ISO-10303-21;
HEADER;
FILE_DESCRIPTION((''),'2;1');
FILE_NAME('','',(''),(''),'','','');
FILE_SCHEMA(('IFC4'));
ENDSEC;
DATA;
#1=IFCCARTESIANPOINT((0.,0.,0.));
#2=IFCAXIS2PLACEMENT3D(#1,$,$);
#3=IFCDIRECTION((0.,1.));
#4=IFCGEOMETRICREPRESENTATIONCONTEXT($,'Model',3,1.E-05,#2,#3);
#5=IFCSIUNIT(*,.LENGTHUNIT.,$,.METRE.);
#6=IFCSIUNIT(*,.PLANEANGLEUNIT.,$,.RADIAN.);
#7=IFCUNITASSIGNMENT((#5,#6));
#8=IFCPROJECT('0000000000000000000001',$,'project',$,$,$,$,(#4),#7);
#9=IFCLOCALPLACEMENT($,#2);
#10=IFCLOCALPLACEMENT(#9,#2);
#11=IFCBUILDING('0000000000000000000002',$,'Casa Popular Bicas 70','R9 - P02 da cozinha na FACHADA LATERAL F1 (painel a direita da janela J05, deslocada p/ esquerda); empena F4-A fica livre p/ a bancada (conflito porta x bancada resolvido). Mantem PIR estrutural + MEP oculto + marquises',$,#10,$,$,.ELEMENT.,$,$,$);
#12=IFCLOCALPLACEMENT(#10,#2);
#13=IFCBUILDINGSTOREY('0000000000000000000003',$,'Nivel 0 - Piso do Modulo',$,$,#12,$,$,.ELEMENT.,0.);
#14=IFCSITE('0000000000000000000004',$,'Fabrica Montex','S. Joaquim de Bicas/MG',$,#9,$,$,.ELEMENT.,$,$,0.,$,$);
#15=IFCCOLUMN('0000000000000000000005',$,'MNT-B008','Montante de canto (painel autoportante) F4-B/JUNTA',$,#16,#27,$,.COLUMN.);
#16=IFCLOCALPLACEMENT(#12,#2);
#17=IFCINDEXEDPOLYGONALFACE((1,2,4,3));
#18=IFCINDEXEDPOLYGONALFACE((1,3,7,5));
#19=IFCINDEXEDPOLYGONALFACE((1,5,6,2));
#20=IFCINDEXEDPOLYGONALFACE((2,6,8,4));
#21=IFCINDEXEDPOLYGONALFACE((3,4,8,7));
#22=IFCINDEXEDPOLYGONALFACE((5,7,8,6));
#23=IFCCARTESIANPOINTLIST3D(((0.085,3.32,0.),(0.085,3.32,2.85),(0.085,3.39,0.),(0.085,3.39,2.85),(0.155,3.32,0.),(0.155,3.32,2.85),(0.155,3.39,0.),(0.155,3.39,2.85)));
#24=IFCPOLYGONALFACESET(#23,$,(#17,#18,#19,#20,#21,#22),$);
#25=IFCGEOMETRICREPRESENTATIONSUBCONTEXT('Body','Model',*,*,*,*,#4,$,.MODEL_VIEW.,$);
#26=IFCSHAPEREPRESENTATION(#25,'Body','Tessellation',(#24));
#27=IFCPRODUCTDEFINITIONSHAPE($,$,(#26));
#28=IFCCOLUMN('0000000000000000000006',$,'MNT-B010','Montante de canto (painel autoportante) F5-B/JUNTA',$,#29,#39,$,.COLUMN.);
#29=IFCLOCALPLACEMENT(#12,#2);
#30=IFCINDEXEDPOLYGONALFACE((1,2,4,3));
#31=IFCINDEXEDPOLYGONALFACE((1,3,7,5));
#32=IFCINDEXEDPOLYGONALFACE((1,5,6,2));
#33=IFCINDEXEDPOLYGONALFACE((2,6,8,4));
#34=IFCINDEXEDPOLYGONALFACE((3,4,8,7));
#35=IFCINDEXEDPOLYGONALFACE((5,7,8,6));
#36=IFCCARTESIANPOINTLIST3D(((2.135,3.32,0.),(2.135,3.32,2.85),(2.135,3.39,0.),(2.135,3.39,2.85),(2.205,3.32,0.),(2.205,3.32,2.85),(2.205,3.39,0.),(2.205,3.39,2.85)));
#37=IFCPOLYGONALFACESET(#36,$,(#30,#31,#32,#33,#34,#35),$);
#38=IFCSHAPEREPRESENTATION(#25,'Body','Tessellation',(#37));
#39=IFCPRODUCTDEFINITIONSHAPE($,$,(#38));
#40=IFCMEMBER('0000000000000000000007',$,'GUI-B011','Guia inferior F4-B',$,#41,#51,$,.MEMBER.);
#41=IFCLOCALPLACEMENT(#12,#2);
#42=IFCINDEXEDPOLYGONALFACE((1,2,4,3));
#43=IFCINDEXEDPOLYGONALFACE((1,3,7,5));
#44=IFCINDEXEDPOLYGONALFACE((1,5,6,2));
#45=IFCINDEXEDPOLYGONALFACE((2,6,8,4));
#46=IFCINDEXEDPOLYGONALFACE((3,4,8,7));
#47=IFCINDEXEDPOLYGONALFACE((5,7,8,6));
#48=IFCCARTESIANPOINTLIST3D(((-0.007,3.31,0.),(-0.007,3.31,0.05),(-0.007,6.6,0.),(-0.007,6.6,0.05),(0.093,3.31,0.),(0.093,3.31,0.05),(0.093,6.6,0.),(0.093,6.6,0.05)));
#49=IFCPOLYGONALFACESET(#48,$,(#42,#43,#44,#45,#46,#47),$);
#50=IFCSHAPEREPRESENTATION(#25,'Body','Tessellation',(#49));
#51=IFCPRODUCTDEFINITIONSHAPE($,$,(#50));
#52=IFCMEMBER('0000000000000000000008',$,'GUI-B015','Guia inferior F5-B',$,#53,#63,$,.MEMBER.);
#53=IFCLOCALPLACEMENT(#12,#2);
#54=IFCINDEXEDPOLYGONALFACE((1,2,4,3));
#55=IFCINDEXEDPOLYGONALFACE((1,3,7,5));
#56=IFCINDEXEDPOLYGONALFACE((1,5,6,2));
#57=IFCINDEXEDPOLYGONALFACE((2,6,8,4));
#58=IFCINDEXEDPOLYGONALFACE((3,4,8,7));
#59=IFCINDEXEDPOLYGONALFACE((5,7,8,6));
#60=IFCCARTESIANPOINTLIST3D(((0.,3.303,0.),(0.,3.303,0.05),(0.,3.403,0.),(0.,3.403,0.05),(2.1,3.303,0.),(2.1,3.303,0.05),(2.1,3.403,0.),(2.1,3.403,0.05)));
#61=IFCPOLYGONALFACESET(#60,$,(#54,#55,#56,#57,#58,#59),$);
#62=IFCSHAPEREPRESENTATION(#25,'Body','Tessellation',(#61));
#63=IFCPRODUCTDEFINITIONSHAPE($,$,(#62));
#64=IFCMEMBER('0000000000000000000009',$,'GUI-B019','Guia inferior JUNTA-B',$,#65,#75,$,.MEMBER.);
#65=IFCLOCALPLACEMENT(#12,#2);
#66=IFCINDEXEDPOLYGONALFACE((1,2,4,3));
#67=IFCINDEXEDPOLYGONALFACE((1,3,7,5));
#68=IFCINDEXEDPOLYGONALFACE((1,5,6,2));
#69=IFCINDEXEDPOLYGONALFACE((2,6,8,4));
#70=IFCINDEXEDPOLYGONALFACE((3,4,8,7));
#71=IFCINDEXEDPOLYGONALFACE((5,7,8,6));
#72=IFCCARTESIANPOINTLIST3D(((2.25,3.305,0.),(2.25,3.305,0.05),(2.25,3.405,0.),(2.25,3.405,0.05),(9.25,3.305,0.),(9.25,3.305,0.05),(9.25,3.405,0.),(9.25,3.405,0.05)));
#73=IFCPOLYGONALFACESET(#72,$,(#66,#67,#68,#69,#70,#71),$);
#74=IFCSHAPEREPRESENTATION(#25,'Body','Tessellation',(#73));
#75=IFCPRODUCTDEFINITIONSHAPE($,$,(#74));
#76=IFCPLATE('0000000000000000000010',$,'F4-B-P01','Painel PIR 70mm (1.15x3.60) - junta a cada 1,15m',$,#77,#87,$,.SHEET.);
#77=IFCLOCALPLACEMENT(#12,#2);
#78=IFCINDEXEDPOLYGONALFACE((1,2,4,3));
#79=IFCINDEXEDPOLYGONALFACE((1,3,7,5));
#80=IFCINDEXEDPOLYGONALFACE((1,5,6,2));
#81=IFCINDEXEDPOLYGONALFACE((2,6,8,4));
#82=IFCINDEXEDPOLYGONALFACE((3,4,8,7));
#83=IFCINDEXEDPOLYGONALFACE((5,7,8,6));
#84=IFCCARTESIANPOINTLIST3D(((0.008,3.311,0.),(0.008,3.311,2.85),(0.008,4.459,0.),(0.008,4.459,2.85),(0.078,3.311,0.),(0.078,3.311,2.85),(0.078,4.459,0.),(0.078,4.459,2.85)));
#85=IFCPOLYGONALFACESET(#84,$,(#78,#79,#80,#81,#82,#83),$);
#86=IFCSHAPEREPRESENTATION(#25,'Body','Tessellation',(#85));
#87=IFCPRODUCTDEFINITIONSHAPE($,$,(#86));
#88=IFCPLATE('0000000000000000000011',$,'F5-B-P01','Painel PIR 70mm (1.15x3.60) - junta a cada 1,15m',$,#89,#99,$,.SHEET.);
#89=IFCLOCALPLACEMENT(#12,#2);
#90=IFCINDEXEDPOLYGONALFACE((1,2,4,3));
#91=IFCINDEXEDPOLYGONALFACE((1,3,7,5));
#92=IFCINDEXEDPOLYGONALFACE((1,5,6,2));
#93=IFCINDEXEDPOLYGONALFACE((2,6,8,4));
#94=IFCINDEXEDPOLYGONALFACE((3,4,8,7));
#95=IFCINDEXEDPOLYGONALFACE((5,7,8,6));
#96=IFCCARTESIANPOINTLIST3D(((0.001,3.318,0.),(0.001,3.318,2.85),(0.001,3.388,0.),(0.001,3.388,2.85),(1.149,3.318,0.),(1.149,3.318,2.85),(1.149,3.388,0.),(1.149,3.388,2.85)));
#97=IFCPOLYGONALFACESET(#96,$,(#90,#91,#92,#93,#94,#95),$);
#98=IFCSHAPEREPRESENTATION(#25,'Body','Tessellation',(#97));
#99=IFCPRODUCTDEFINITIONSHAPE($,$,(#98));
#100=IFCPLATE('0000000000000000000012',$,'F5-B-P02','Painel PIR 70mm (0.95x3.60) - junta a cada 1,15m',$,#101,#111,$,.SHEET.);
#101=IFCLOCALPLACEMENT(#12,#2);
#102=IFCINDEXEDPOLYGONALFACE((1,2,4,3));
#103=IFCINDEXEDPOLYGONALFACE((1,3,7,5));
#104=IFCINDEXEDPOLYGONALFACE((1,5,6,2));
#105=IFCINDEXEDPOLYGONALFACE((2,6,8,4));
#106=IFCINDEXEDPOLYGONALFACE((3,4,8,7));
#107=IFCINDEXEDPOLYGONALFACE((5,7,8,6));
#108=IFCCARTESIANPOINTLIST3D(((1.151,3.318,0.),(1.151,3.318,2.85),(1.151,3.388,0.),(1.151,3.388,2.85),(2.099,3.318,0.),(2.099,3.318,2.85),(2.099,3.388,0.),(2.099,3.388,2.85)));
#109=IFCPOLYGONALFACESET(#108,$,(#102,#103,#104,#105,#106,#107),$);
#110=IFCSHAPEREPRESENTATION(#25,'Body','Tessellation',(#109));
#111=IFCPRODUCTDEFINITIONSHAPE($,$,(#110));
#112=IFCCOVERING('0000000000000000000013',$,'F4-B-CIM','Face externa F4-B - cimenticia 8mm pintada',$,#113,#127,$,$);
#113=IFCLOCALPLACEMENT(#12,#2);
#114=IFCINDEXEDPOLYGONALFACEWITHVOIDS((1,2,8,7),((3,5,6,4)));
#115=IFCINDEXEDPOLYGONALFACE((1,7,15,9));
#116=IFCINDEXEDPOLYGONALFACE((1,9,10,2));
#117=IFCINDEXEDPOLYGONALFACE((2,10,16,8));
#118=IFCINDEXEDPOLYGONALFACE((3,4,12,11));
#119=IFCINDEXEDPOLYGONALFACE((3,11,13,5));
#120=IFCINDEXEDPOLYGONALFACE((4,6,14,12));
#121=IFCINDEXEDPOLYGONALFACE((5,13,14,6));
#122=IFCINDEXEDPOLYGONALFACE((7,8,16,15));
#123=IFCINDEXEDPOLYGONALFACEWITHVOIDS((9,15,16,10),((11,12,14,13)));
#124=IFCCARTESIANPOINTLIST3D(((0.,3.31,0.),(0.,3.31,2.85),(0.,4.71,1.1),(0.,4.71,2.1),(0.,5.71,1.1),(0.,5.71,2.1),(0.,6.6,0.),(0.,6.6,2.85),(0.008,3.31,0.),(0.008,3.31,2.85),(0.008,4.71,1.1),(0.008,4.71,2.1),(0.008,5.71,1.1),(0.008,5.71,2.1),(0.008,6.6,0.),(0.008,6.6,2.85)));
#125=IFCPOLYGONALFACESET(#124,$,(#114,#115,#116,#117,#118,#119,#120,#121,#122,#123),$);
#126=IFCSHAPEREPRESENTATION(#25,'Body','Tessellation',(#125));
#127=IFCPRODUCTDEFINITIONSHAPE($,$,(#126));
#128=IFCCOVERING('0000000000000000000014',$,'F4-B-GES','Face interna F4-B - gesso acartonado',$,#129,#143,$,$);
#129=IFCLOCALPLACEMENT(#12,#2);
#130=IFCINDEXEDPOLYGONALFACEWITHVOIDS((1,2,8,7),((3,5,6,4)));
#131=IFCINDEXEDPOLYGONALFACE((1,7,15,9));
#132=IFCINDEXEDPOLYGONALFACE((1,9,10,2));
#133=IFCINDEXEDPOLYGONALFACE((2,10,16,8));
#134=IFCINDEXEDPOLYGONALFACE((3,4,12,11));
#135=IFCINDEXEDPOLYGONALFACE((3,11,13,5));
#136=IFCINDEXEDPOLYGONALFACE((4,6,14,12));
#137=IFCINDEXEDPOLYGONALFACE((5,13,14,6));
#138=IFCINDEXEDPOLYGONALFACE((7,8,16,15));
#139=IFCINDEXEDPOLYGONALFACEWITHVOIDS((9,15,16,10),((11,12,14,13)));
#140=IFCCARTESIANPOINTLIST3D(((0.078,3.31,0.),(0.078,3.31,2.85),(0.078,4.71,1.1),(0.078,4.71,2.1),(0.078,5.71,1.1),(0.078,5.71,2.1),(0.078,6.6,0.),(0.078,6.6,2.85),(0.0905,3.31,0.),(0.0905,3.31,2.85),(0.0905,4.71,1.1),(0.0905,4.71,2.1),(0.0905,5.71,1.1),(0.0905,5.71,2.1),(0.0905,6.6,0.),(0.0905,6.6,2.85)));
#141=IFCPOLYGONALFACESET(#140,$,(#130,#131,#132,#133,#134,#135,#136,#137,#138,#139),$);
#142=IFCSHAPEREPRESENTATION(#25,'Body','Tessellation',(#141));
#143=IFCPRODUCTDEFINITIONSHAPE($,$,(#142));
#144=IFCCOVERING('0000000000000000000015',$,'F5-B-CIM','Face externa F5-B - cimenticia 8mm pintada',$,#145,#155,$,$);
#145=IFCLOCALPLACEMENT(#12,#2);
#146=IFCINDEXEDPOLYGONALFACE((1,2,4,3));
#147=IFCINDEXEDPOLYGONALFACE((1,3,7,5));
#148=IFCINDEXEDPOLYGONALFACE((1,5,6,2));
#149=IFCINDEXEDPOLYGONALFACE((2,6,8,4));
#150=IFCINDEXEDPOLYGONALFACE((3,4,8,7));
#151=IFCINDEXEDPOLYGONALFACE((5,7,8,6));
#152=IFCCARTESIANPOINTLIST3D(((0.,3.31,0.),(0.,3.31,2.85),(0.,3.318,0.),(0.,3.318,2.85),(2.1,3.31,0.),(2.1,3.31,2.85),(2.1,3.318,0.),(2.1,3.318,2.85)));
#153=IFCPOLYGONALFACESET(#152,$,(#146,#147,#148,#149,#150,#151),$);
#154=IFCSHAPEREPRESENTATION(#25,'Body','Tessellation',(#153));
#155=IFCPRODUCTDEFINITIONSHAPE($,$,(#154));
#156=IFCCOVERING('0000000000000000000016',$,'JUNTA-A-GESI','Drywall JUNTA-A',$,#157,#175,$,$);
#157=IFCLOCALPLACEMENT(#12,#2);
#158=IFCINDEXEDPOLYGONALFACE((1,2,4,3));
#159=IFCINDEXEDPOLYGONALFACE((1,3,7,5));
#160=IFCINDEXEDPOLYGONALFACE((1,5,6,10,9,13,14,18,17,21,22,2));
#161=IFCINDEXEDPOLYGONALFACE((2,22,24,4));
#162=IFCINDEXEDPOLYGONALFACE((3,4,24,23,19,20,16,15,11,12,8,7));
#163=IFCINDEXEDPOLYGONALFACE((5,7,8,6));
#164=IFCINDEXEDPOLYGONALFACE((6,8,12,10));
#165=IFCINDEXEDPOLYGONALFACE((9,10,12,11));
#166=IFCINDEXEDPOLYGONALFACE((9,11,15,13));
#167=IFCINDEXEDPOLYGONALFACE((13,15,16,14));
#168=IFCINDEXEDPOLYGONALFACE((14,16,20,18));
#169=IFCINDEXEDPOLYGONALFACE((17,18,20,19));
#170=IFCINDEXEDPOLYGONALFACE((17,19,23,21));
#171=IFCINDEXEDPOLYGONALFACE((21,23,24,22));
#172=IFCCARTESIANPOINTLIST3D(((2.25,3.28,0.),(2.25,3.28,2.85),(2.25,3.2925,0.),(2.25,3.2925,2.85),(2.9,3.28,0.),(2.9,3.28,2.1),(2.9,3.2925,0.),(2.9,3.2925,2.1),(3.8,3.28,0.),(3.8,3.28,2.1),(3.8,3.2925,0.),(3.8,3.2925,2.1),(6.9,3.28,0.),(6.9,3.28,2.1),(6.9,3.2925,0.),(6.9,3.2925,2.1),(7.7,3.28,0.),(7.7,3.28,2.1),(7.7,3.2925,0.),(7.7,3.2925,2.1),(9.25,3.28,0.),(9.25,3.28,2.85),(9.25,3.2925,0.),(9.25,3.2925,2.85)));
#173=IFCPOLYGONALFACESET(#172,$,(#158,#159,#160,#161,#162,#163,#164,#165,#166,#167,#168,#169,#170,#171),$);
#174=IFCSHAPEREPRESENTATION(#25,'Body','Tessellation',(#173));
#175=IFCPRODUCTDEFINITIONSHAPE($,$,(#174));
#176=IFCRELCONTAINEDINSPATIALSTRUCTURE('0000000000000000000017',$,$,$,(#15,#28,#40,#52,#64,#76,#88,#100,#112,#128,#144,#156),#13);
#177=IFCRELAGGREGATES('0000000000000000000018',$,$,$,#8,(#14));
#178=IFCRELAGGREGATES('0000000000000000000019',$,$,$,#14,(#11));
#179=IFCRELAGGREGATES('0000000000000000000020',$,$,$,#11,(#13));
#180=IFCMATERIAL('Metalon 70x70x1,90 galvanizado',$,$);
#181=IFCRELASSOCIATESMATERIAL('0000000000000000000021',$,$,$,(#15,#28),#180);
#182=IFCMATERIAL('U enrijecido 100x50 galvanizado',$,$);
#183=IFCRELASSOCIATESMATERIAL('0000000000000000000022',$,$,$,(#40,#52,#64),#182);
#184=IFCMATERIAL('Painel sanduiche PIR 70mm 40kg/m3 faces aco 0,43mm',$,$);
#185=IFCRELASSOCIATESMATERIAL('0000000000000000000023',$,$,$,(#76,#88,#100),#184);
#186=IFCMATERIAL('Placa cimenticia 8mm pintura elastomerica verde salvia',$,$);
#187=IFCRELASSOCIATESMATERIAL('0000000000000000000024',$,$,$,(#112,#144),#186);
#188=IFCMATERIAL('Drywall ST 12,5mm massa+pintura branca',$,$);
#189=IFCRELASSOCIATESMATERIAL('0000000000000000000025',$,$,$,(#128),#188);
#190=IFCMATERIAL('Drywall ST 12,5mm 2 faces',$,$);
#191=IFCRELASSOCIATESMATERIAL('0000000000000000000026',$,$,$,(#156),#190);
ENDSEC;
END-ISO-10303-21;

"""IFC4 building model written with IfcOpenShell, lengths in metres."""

from ifc_helpers import new_model, si_unit, direction, frame, frame_2d, origin, origin_2d, place, context, subcontext, project, spatial, rectangle, extrude, material, element, save


model = new_model("IFC4")

# Units and contexts
model_context = context("Model", 3, precision=1e-05, world=origin(), true_north=direction((0.0, 1.0)))
body_context = subcontext(model_context, "Body", "Model", "MODEL_VIEW")
ifc_project = project(units=[si_unit("LENGTHUNIT", "METRE"), si_unit("PLANEANGLEUNIT", "RADIAN")], contexts=[model_context])

# Site, building, storey
site_placement = place(None, origin())
site = spatial("IfcSite", under=ifc_project, at=site_placement, Name="Fabrica Montex", Description="S. Joaquim de Bicas/MG", CompositionType="ELEMENT", RefElevation=0.0)
building_placement = place(site_placement, origin())
building = spatial("IfcBuilding", under=site, at=building_placement, Name="Casa Popular Bicas 70", Description="R9 - P02 da cozinha na FACHADA LATERAL F1 (painel a direita da janela J05, deslocada p/ esquerda); empena F4-A fica livre p/ a bancada (conflito porta x bancada resolvido). Mantem PIR estrutural + MEP oculto + marquises", CompositionType="ELEMENT")
storey_placement = place(building_placement, origin())
storey = spatial("IfcBuildingStorey", under=building, at=storey_placement, Name="Nivel 0 - Piso do Modulo", CompositionType="ELEMENT", Elevation=0.0)

# Columns
ifc_material_1 = material(Name="Metalon 70x70x1,90 galvanizado")
for number, where, name, description in (
    (1, (0.12, 3.355, 0.0), "MNT-B008", "Montante de canto (painel autoportante) F4-B/JUNTA"),
    (2, (2.17, 3.355, 0.0), "MNT-B010", "Montante de canto (painel autoportante) F5-B/JUNTA"),
):
    element("IfcColumn", number, at=place(storey_placement, frame(where)), inside=storey, material=ifc_material_1, Name=name, Description=description, PredefinedType="COLUMN", context=body_context, shape_type="SweptSolid", body=[
        extrude(rectangle(XDim=0.07, YDim=0.07, at=origin_2d()), origin(), (0.0, 0.0, 1.0), 2.85),
    ])

# Members
ifc_material_2 = material(Name="U enrijecido 100x50 galvanizado")
member_1_placement = place(storey_placement, frame((0.043, 3.31, 0.025), z_axis=(0.0, 1.0, 0.0), x_axis=(0.0, 0.0, 1.0)))
element("IfcMember", 3, at=member_1_placement, inside=storey, material=ifc_material_2, Name="GUI-B011", Description="Guia inferior F4-B", PredefinedType="MEMBER", context=body_context, shape_type="SweptSolid", body=[
    extrude(rectangle(XDim=0.05, YDim=0.1, at=origin_2d()), origin(), (0.0, 0.0, 1.0), 3.29),
])
member_2_placement = place(storey_placement, frame((0.0, 3.353, 0.025), z_axis=(1.0, 0.0, 0.0), x_axis=(0.0, 0.0, 1.0)))
element("IfcMember", 4, at=member_2_placement, inside=storey, material=ifc_material_2, Name="GUI-B015", Description="Guia inferior F5-B", PredefinedType="MEMBER", context=body_context, shape_type="SweptSolid", body=[
    extrude(rectangle(XDim=0.05, YDim=0.1, at=origin_2d()), origin(), (0.0, 0.0, 1.0), 2.1),
])
member_3_placement = place(storey_placement, frame((2.25, 3.355, 0.025), z_axis=(1.0, 0.0, 0.0), x_axis=(0.0, 0.0, 1.0)))
element("IfcMember", 5, at=member_3_placement, inside=storey, material=ifc_material_2, Name="GUI-B019", Description="Guia inferior JUNTA-B", PredefinedType="MEMBER", context=body_context, shape_type="SweptSolid", body=[
    extrude(rectangle(XDim=0.05, YDim=0.1, at=origin_2d()), origin(), (0.0, 0.0, 1.0), 7.0),
])

# Plates
ifc_material_3 = material(Name="Painel sanduiche PIR 70mm 40kg/m3 faces aco 0,43mm")
for number, where, x_axis, name in (
    (6, (0.043, 3.311, 0.0), (0.0, 1.0, 0.0), "F4-B-P01"),
    (7, (0.001, 3.353, 0.0), (1.0, 0.0, 0.0), "F5-B-P01"),
):
    element("IfcPlate", number, at=place(storey_placement, frame(where, x_axis=x_axis)), inside=storey, material=ifc_material_3, Name=name, Description="Painel PIR 70mm (1.15x3.60) - junta a cada 1,15m", PredefinedType="SHEET", context=body_context, shape_type="SweptSolid", body=[
        extrude(rectangle(XDim=1.148, YDim=0.07, at=frame_2d((0.574, 0.0))), origin(), (0.0, 0.0, 1.0), 2.85),
    ])
plate_1_placement = place(storey_placement, frame((1.151, 3.353, 0.0), x_axis=(1.0, 0.0, 0.0)))
element("IfcPlate", 8, at=plate_1_placement, inside=storey, material=ifc_material_3, Name="F5-B-P02", Description="Painel PIR 70mm (0.95x3.60) - junta a cada 1,15m", PredefinedType="SHEET", context=body_context, shape_type="SweptSolid", body=[
    extrude(rectangle(XDim=0.948, YDim=0.07, at=frame_2d((0.474, 0.0))), origin(), (0.0, 0.0, 1.0), 2.85),
])

# Coverings, openings
ifc_material_4 = material(Name="Placa cimenticia 8mm pintura elastomerica verde salvia")
covering_1_placement = place(storey_placement, frame((0.004, 3.31, 0.0), x_axis=(0.0, 1.0, 0.0)))
covering_1 = element("IfcCovering", 9, at=covering_1_placement, inside=storey, material=ifc_material_4, Name="F4-B-CIM", Description="Face externa F4-B - cimenticia 8mm pintada", context=body_context, shape_type="SweptSolid", body=[
    extrude(rectangle(XDim=3.29, YDim=0.008, at=frame_2d((1.645, 0.0))), origin(), (0.0, 0.0, 1.0), 2.85),
])
opening_1_placement = place(storey_placement, frame((0.004, 5.21, 1.1)))
element("IfcOpeningElement", 10, at=opening_1_placement, cuts=covering_1, PredefinedType="OPENING", context=body_context, shape_type="SweptSolid", body=[
    extrude(rectangle(XDim=0.038, YDim=1.0, at=origin_2d()), origin(), (0.0, 0.0, 1.0), 1.0),
])
ifc_material_5 = material(Name="Drywall ST 12,5mm massa+pintura branca")
covering_2_placement = place(storey_placement, frame((0.0843, 3.31, 0.0), x_axis=(0.0, 1.0, 0.0)))
covering_2 = element("IfcCovering", 11, at=covering_2_placement, inside=storey, material=ifc_material_5, Name="F4-B-GES", Description="Face interna F4-B - gesso acartonado", context=body_context, shape_type="SweptSolid", body=[
    extrude(rectangle(XDim=3.29, YDim=0.0125, at=frame_2d((1.645, 0.0))), origin(), (0.0, 0.0, 1.0), 2.85),
])
opening_2_placement = place(storey_placement, frame((0.0843, 5.21, 1.1)))
element("IfcOpeningElement", 12, at=opening_2_placement, cuts=covering_2, PredefinedType="OPENING", context=body_context, shape_type="SweptSolid", body=[
    extrude(rectangle(XDim=0.0425, YDim=1.0, at=origin_2d()), origin(), (0.0, 0.0, 1.0), 1.0),
])

# Covering
covering_3_placement = place(storey_placement, frame((0.0, 3.314, 0.0), x_axis=(1.0, 0.0, 0.0)))
element("IfcCovering", 13, at=covering_3_placement, inside=storey, material=ifc_material_4, Name="F5-B-CIM", Description="Face externa F5-B - cimenticia 8mm pintada", context=body_context, shape_type="SweptSolid", body=[
    extrude(rectangle(XDim=2.1, YDim=0.008, at=frame_2d((1.05, 0.0))), origin(), (0.0, 0.0, 1.0), 2.85),
])

# Covering, openings
ifc_material_6 = material(Name="Drywall ST 12,5mm 2 faces")
covering_4_placement = place(storey_placement, frame((2.25, 3.2862, 0.0), x_axis=(1.0, 0.0, 0.0)))
covering_4 = element("IfcCovering", 14, at=covering_4_placement, inside=storey, material=ifc_material_6, Name="JUNTA-A-GESI", Description="Drywall JUNTA-A", context=body_context, shape_type="SweptSolid", body=[
    extrude(rectangle(XDim=7.0, YDim=0.0125, at=frame_2d((3.5, 0.0))), origin(), (0.0, 0.0, 1.0), 2.85),
])
opening_3_placement = place(storey_placement, frame((3.35, 3.2862, 0.0)))
element("IfcOpeningElement", 15, at=opening_3_placement, cuts=covering_4, PredefinedType="OPENING", context=body_context, shape_type="SweptSolid", body=[
    extrude(rectangle(XDim=0.9, YDim=0.0425, at=origin_2d()), origin(), (0.0, 0.0, 1.0), 2.1),
])
opening_4_placement = place(storey_placement, frame((7.3, 3.2862, 0.0)))
element("IfcOpeningElement", 16, at=opening_4_placement, cuts=covering_4, PredefinedType="OPENING", context=body_context, shape_type="SweptSolid", body=[
    extrude(rectangle(XDim=0.8, YDim=0.0425, at=origin_2d()), origin(), (0.0, 0.0, 1.0), 2.1),
])

save(model, "model.ifc")
